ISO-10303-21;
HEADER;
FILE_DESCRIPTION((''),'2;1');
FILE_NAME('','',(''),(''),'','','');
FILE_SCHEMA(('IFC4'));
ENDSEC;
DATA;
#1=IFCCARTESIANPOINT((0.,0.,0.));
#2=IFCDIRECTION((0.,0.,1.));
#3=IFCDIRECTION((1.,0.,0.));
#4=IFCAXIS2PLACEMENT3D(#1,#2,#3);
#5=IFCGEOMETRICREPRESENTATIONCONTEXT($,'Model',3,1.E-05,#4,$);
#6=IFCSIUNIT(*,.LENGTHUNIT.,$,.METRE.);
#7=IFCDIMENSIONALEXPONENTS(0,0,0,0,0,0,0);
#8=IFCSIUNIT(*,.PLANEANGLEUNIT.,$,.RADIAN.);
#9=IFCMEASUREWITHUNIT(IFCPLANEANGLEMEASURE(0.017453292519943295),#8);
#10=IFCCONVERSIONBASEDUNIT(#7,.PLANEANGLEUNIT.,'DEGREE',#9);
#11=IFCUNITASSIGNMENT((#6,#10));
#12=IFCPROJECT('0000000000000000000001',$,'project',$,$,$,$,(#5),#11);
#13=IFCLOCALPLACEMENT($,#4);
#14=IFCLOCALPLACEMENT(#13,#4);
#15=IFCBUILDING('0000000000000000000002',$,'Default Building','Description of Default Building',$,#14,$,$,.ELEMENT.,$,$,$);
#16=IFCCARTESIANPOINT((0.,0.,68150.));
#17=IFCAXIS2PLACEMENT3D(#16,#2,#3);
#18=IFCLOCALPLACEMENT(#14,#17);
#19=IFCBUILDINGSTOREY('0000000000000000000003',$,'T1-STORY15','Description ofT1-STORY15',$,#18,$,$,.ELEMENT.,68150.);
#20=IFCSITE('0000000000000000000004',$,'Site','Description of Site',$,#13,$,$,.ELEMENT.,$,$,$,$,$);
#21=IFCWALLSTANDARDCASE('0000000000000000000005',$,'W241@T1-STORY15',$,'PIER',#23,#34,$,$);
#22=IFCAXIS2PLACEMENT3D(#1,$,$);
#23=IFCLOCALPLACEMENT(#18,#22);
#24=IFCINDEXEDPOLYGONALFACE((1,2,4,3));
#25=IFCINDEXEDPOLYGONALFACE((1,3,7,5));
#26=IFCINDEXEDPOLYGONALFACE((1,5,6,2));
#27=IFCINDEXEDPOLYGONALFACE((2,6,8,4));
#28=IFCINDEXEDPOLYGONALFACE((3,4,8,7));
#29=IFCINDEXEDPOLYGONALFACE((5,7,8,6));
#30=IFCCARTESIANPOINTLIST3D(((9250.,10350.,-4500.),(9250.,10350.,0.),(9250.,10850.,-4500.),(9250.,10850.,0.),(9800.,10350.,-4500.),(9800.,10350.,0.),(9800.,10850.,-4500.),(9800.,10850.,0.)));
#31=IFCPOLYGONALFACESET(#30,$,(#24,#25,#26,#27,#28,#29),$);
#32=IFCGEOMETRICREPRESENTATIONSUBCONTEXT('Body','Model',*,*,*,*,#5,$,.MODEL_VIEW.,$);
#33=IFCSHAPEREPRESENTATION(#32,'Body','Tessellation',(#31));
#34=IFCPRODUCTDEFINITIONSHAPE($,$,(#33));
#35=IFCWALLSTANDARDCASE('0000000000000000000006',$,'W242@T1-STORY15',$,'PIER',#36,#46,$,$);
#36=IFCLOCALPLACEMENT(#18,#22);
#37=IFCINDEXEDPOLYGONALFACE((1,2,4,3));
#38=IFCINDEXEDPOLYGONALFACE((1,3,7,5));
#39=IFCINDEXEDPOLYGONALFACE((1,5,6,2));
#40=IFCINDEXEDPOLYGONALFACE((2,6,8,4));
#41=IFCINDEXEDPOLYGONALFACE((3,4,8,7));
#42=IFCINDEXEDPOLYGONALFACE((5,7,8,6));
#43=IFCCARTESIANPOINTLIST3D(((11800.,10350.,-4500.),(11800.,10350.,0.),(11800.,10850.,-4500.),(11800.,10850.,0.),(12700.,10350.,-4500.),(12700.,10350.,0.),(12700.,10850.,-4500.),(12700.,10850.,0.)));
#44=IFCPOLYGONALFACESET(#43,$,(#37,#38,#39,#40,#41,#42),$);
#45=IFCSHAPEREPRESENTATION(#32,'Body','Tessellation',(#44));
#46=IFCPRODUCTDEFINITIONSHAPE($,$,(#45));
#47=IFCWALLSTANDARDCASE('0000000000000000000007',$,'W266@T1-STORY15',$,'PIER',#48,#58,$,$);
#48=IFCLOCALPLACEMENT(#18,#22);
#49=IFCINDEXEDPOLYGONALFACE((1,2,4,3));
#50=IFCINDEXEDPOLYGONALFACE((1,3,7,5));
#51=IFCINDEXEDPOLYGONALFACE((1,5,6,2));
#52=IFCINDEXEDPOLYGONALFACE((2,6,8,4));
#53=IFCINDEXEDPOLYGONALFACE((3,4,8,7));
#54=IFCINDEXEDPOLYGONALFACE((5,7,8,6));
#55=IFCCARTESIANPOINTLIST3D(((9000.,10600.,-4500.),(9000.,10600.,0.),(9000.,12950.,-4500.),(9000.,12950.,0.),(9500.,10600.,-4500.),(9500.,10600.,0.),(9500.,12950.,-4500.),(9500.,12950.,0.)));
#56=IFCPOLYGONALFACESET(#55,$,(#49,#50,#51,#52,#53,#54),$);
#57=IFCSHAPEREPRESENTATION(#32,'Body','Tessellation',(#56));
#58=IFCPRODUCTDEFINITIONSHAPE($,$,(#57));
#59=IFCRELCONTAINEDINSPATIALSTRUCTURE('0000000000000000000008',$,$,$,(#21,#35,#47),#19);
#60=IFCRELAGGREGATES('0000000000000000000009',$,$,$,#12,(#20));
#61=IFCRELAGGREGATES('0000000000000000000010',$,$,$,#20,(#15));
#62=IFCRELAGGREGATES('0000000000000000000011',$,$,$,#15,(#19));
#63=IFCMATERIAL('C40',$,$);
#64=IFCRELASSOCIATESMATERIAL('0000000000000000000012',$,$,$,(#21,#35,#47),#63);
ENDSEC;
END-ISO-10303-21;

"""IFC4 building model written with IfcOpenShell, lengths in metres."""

from ifc_helpers import new_model, entity, si_unit, converted_unit, frame, origin_with_axes, place, context, subcontext, project, spatial, indexed_curve, outline, extrude, material, element, save


model = new_model("IFC4")

# Units and contexts
model_context = context("Model", 3, precision=1e-05, world=origin_with_axes())
body_context = subcontext(model_context, "Body", "Model", "MODEL_VIEW")
ifc_project = project(units=[si_unit("LENGTHUNIT", "METRE"), converted_unit("PLANEANGLEUNIT", "DEGREE", entity("IfcPlaneAngleMeasure", 0.017453292519943295), si_unit("PLANEANGLEUNIT", "RADIAN"), dimensions=[0, 0, 0, 0, 0, 0, 0])], contexts=[model_context])

# Site, building, storey
site_placement = place(None, origin_with_axes())
site = spatial("IfcSite", under=ifc_project, at=site_placement, Name="Site", Description="Description of Site", CompositionType="ELEMENT")
building_placement = place(site_placement, origin_with_axes())
building = spatial("IfcBuilding", under=site, at=building_placement, Name="Default Building", Description="Description of Default Building", CompositionType="ELEMENT")
storey_placement = place(building_placement, frame((0.0, 0.0, 68150.0), z_axis=(0.0, 0.0, 1.0), x_axis=(1.0, 0.0, 0.0)))
storey = spatial("IfcBuildingStorey", under=building, at=storey_placement, Name="T1-STORY15", Description="Description ofT1-STORY15", CompositionType="ELEMENT", Elevation=68150.0)

# Shared definitions
ifc_material_1 = material(Name="C40")

# Walls
wall_1_placement = place(storey_placement, frame((9250.0, 10600.0, -4500.0), z_axis=(0.0, 0.0, 1.0), x_axis=(1.0, 0.0, 0.0)))
element("IfcWallStandardCase", 1, at=wall_1_placement, inside=storey, material=ifc_material_1, Name="W241@T1-STORY15", ObjectType="PIER", context=body_context, shape_type="SweptSolid", body=[
    extrude(outline(indexed_curve([(0.0, -250.0), (0.0, 250.0), (550.0, 250.0), (550.0, -250.0), (0.0, -250.0)], self_intersect=False)), origin_with_axes(), (0.0, 0.0, 1.0), 4500.0),
])
wall_2_placement = place(storey_placement, frame((11800.0, 10600.0, -4500.0), z_axis=(0.0, 0.0, 1.0), x_axis=(1.0, 0.0, 0.0)))
element("IfcWallStandardCase", 2, at=wall_2_placement, inside=storey, material=ifc_material_1, Name="W242@T1-STORY15", ObjectType="PIER", context=body_context, shape_type="SweptSolid", body=[
    extrude(outline(indexed_curve([(0.0, -250.0), (0.0, 250.0), (900.0, 250.0), (900.0, -250.0), (0.0, -250.0)], self_intersect=False)), origin_with_axes(), (0.0, 0.0, 1.0), 4500.0),
])
wall_3_placement = place(storey_placement, frame((9250.0, 10600.0, -4500.0), z_axis=(0.0, 0.0, 1.0), x_axis=(0.0, 1.0, 0.0)))
element("IfcWallStandardCase", 3, at=wall_3_placement, inside=storey, material=ifc_material_1, Name="W266@T1-STORY15", ObjectType="PIER", context=body_context, shape_type="SweptSolid", body=[
    extrude(outline(indexed_curve([(0.0, -250.0), (0.0, 250.0), (2350.0, 250.0), (2350.0, -250.0), (0.0, -250.0)], self_intersect=False)), origin_with_axes(), (0.0, 0.0, 1.0), 4500.0),
])

save(model, "model.ifc")
